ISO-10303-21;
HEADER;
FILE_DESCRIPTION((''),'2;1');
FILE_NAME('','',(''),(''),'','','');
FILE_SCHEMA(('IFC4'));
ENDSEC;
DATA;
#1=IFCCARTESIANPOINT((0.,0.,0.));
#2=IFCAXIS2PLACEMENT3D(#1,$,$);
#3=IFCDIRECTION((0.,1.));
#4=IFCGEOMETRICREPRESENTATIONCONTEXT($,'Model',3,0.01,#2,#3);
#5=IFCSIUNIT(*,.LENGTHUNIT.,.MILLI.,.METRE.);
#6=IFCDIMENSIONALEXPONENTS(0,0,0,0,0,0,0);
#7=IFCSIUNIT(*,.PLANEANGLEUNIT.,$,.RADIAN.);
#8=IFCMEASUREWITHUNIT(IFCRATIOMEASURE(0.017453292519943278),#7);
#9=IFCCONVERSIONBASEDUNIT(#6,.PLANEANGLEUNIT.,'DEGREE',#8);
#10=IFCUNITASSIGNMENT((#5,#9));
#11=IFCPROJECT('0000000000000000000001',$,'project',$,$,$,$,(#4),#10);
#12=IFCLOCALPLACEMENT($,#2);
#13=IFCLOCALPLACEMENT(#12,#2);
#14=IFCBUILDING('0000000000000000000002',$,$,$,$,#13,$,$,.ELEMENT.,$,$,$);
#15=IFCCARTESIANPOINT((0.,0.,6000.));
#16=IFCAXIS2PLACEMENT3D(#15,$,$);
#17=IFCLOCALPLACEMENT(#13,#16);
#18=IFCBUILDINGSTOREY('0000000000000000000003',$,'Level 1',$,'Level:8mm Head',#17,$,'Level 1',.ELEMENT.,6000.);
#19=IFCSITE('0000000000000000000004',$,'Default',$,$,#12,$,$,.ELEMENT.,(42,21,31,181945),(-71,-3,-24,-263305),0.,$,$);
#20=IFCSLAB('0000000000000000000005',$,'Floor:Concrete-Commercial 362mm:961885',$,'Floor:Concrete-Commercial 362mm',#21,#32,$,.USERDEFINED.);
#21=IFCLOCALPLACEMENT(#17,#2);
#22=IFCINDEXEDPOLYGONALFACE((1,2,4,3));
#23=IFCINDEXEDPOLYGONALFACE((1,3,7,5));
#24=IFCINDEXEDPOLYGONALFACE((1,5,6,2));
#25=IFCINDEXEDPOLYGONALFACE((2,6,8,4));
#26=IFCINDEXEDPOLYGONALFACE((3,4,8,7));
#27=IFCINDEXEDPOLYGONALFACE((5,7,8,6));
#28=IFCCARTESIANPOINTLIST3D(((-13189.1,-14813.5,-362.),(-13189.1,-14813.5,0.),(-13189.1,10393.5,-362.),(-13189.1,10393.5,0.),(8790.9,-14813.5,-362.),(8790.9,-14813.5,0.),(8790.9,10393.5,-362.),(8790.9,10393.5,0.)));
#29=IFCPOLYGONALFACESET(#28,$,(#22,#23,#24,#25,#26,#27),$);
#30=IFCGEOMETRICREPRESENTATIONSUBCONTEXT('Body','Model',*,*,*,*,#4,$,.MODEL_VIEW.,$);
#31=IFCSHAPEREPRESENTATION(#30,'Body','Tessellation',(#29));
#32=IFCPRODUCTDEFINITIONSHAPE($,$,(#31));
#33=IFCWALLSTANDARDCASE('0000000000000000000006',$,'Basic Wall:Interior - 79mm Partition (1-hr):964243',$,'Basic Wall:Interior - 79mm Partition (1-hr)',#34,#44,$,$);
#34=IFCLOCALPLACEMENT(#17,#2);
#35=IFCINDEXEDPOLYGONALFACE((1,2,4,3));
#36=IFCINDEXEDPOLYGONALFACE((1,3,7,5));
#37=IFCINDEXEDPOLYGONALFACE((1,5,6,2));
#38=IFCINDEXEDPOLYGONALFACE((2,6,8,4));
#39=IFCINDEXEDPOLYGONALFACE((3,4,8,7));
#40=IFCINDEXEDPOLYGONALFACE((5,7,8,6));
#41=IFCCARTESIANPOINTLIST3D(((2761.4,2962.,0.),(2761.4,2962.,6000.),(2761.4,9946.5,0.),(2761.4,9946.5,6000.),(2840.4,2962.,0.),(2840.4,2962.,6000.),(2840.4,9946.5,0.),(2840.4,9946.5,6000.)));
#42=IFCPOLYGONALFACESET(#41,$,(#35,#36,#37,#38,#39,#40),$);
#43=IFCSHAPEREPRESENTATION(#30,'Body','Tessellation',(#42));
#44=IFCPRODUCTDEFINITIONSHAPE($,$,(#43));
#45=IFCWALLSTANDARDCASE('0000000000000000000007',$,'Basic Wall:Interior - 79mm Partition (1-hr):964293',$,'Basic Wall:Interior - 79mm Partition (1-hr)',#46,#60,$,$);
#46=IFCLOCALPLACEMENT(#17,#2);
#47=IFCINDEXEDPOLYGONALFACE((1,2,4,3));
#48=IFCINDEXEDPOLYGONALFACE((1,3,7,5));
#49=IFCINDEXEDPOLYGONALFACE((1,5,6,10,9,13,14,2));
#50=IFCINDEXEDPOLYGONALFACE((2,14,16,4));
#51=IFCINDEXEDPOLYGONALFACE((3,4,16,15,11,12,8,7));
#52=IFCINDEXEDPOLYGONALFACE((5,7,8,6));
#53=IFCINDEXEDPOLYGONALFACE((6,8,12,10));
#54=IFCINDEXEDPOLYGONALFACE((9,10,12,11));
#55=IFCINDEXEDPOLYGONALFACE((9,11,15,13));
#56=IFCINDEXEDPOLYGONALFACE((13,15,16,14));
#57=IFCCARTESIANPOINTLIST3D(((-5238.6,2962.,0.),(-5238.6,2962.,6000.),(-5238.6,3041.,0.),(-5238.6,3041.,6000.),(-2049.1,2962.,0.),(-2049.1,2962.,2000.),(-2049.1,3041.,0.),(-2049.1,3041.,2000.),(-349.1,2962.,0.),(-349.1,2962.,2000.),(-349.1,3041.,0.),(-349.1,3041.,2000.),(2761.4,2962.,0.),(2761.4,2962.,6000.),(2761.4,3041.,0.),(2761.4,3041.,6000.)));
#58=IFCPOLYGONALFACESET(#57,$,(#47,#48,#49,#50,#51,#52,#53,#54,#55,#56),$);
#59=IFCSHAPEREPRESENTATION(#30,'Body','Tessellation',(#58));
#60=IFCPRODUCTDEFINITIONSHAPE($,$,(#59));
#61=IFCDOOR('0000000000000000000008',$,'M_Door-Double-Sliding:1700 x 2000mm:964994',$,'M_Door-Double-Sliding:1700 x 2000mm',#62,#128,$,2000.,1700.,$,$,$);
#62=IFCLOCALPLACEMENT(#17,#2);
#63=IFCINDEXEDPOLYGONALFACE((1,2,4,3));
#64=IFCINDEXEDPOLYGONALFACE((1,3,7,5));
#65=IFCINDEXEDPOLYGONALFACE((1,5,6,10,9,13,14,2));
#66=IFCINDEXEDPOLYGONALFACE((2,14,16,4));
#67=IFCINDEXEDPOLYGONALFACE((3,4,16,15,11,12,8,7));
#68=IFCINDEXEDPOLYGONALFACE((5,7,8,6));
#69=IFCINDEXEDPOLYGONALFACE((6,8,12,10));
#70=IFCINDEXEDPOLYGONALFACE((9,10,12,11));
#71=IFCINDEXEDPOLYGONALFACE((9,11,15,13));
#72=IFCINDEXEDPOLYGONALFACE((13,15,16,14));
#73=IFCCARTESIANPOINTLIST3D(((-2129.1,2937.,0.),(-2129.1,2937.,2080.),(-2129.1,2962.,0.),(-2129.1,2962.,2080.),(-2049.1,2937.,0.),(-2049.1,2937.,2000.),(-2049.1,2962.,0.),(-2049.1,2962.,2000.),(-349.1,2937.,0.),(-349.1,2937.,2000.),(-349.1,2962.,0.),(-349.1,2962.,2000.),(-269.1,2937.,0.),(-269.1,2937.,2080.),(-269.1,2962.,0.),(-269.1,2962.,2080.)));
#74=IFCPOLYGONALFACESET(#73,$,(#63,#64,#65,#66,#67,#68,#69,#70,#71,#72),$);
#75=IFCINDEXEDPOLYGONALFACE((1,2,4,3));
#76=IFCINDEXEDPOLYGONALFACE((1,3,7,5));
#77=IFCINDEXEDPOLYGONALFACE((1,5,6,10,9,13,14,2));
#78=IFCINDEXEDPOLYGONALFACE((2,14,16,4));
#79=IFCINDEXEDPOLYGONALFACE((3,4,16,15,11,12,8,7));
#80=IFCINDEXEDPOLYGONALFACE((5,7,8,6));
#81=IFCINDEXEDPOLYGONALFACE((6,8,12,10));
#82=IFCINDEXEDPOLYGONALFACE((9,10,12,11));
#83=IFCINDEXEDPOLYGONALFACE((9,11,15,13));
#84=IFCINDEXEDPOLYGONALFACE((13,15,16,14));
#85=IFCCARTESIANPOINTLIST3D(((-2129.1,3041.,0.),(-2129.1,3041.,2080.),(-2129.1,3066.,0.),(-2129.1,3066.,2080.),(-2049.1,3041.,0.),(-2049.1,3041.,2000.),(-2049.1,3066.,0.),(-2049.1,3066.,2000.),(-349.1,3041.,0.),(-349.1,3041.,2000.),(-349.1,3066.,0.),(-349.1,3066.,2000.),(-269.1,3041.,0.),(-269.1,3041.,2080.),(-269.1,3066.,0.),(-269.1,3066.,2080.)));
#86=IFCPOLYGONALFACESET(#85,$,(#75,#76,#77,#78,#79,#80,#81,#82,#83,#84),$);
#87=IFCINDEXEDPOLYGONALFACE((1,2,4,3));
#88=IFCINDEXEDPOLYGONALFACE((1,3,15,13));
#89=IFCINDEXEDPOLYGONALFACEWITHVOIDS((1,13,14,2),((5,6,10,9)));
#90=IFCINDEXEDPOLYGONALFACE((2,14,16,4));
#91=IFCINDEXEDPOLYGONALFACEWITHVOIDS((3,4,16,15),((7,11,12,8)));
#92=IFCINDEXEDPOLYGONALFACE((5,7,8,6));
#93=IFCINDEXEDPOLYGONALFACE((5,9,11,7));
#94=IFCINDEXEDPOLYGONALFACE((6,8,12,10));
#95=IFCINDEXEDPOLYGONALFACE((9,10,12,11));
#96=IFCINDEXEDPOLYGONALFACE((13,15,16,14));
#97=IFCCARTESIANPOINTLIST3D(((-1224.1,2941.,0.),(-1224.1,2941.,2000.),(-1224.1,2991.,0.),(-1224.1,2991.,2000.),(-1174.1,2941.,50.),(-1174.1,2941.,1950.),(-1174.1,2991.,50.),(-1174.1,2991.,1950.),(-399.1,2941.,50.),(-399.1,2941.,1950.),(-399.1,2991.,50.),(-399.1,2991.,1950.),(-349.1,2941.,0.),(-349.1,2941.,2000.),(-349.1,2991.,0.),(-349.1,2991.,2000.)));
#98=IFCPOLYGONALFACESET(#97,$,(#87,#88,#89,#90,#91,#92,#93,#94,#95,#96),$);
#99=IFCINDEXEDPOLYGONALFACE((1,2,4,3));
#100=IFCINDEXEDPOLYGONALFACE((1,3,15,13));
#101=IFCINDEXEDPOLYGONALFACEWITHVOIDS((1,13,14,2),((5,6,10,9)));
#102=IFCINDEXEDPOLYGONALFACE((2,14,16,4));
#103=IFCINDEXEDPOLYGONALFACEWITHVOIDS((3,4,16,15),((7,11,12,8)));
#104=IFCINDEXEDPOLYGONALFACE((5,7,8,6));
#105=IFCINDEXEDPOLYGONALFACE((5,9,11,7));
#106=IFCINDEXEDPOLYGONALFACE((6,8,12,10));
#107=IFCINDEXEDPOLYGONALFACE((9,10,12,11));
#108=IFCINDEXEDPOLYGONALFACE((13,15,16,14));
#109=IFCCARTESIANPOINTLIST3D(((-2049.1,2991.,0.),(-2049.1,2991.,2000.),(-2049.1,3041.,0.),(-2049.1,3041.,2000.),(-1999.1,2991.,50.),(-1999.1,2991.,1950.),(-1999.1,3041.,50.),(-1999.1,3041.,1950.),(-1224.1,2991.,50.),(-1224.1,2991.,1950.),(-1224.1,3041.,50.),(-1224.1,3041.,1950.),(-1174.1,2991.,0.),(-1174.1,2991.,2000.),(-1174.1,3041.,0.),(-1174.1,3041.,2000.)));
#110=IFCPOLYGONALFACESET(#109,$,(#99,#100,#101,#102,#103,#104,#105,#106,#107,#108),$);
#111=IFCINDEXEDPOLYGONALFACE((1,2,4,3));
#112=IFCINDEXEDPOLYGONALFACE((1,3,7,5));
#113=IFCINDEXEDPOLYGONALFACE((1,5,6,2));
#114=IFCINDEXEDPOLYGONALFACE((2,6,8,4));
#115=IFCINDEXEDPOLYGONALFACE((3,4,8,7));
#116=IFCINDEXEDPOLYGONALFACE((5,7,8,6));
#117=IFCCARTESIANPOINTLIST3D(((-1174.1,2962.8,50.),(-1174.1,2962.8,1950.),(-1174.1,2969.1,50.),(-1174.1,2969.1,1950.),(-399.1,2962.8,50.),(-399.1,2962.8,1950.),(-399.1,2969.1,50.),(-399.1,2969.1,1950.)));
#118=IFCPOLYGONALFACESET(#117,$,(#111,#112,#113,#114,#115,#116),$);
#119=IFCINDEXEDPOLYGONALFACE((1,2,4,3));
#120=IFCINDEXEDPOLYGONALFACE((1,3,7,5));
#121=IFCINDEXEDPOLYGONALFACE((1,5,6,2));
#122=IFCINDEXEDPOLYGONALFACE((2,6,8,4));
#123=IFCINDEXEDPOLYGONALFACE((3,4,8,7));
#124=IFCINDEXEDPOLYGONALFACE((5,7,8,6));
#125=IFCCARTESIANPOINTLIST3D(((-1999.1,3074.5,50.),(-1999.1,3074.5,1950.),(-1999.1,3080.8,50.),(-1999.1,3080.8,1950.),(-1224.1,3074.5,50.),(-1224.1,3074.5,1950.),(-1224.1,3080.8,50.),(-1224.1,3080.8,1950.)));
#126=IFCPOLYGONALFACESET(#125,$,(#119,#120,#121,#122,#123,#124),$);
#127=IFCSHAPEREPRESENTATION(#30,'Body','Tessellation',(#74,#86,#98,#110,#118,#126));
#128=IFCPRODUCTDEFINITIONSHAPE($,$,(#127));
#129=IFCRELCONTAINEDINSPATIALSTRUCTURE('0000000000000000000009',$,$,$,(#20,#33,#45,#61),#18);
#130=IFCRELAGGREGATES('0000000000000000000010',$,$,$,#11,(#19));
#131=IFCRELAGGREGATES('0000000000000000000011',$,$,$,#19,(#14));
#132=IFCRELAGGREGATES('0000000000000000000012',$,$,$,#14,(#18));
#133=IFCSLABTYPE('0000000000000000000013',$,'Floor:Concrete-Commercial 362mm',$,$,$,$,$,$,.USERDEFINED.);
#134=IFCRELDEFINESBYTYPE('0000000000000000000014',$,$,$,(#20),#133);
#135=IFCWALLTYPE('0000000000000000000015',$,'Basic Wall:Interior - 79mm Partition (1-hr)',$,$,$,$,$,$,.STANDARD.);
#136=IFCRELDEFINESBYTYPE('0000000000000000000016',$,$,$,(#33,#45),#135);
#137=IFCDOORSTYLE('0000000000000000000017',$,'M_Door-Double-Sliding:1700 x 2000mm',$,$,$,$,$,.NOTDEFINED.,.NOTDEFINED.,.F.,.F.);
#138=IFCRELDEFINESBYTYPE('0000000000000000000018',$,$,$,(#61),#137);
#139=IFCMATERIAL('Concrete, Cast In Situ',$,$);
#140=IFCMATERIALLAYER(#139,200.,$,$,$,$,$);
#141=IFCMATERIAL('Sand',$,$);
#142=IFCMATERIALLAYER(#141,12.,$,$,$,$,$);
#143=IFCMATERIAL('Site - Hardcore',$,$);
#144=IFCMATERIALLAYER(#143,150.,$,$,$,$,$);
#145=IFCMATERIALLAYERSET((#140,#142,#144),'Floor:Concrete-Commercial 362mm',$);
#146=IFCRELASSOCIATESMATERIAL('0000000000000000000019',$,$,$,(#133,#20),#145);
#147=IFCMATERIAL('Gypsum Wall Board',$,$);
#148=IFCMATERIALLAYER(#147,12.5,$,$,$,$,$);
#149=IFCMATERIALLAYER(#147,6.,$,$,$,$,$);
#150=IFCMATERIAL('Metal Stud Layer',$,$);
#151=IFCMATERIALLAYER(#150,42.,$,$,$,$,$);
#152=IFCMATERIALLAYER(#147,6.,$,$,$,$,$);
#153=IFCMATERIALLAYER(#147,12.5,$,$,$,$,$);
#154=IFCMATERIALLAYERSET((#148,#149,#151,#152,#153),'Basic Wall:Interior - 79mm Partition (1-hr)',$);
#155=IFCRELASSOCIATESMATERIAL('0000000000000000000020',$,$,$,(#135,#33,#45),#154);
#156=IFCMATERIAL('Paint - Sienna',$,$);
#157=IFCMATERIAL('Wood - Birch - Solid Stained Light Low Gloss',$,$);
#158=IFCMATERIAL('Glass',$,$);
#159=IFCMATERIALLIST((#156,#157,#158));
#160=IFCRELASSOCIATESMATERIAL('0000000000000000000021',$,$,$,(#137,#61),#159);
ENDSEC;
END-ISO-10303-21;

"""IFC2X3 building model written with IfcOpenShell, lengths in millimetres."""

from ifc_helpers import new_model, entity, si_unit, converted_unit, direction, frame, frame_2d, origin, origin_2d_with_axis, place, context, subcontext, project, spatial, polyline, rectangle, outline, extrude, source, transform, mapped, material, material_list, layer, layer_set, layer_usage, type_object, type_shapes, element, fill, save


model = new_model("IFC2X3")

# Units and contexts
model_context = context("Model", 3, precision=0.01, world=origin(), true_north=direction((0.0, 1.0)))
body_context = subcontext(model_context, "Body", "Model", "MODEL_VIEW")
ifc_project = project(units=[si_unit("LENGTHUNIT", "METRE", prefix="MILLI"), converted_unit("PLANEANGLEUNIT", "DEGREE", entity("IfcRatioMeasure", 0.017453292519943278), si_unit("PLANEANGLEUNIT", "RADIAN"), dimensions=[0, 0, 0, 0, 0, 0, 0])], contexts=[model_context])

# Site, building, storey
site_placement = place(None, origin())
site = spatial("IfcSite", under=ifc_project, at=site_placement, Name="Default", CompositionType="ELEMENT", RefLatitude=(42, 21, 31, 181945), RefLongitude=(-71, -3, -24, -263305), RefElevation=0.0)
building_placement = place(site_placement, origin())
building = spatial("IfcBuilding", under=site, at=building_placement, CompositionType="ELEMENT")
storey_placement = place(building_placement, frame((0.0, 0.0, 6000.0)))
storey = spatial("IfcBuildingStorey", under=building, at=storey_placement, Name="Level 1", ObjectType="Level:8mm Head", LongName="Level 1", CompositionType="ELEMENT", Elevation=6000.0)

# Slab
ifc_material_1 = material(Name="Concrete, Cast In Situ")
ifc_layer_1 = layer(ifc_material_1, 200.0)
ifc_material_2 = material(Name="Sand")
ifc_layer_2 = layer(ifc_material_2, 12.0)
ifc_material_3 = material(Name="Site - Hardcore")
ifc_layer_3 = layer(ifc_material_3, 150.0)
ifc_layer_set_1 = layer_set([ifc_layer_1, ifc_layer_2, ifc_layer_3], Name="Floor:Concrete-Commercial 362mm")
ifc_layer_usage_1 = layer_usage(ifc_layer_set_1, "AXIS3", "POSITIVE", 0.0)
slab_type = type_object("IfcSlabType", Name="Floor:Concrete-Commercial 362mm", PredefinedType="USERDEFINED", material=ifc_layer_set_1)
slab_placement = place(storey_placement, origin())
element("IfcSlab", 1, at=slab_placement, inside=storey, type_object=slab_type, material=ifc_layer_usage_1, Name="Floor:Concrete-Commercial 362mm:961885", ObjectType="Floor:Concrete-Commercial 362mm", PredefinedType="USERDEFINED", context=body_context, shape_type="SweptSolid", body=[
    extrude(rectangle(XDim=25207.0, YDim=21980.0, at=frame_2d((0.0, 0.0), x_axis=(1.0, 0.0))), frame((-2199.1, -2210.0, 0.0), z_axis=(0.0, 0.0, -1.0), x_axis=(0.0, 1.0, 0.0)), (0.0, 0.0, 1.0), 362.0),
])

# Wall
ifc_material_4 = material(Name="Gypsum Wall Board")
ifc_layer_4 = layer(ifc_material_4, 12.5)
ifc_layer_5 = layer(ifc_material_4, 6.0)
ifc_material_5 = material(Name="Metal Stud Layer")
ifc_layer_6 = layer(ifc_material_5, 42.0)
ifc_layer_7 = layer(ifc_material_4, 6.0)
ifc_layer_8 = layer(ifc_material_4, 12.5)
ifc_layer_set_2 = layer_set([ifc_layer_4, ifc_layer_5, ifc_layer_6, ifc_layer_7, ifc_layer_8], Name="Basic Wall:Interior - 79mm Partition (1-hr)")
ifc_layer_usage_2 = layer_usage(ifc_layer_set_2, "AXIS2", "NEGATIVE", 39.5)
wall_type = type_object("IfcWallType", Name="Basic Wall:Interior - 79mm Partition (1-hr)", PredefinedType="STANDARD", material=ifc_layer_set_2)
wall_1_placement = place(storey_placement, frame((2800.9, 9946.5, 0.0), z_axis=(0.0, 0.0, 1.0), x_axis=(0.0, -1.0, 0.0)))
element("IfcWallStandardCase", 2, at=wall_1_placement, inside=storey, type_object=wall_type, material=ifc_layer_usage_2, Name="Basic Wall:Interior - 79mm Partition (1-hr):964243", ObjectType="Basic Wall:Interior - 79mm Partition (1-hr)", context=body_context, shape_type="SweptSolid", body=[
    extrude(rectangle(XDim=6984.5, YDim=79.0, at=frame_2d((3492.3, 0.0), x_axis=(-1.0, 0.0))), origin(), (0.0, 0.0, 1.0), 6000.0),
])

# Wall, opening, door
wall_2_placement = place(storey_placement, frame((2761.4, 3001.5, 0.0), z_axis=(0.0, 0.0, 1.0), x_axis=(-1.0, 0.0, 0.0)))
wall_2 = element("IfcWallStandardCase", 3, at=wall_2_placement, inside=storey, type_object=wall_type, material=ifc_layer_usage_2, Name="Basic Wall:Interior - 79mm Partition (1-hr):964293", ObjectType="Basic Wall:Interior - 79mm Partition (1-hr)", context=body_context, shape_type="SweptSolid", body=[
    extrude(rectangle(XDim=8000.0, YDim=79.0, at=frame_2d((4000.0, 0.0), x_axis=(-1.0, 0.0))), origin(), (0.0, 0.0, 1.0), 6000.0),
])
opening_1_placement = place(wall_2_placement, frame((4810.5, 39.5, 0.0)))
opening_1 = element("IfcOpeningElement", 4, at=opening_1_placement, cuts=wall_2, ObjectType="Opening", context=body_context, shape_type="SweptSolid", body=[
    extrude(rectangle(XDim=2000.0, YDim=1700.0, at=frame_2d((1000.0, 850.0), x_axis=(-1.0, 0.0))), frame((0.0, 0.0, 0.0), z_axis=(0.0, -1.0, 0.0), x_axis=(0.0, 0.0, 1.0)), (0.0, 0.0, 1.0), 79.0),
])
ifc_material_6 = material(Name="Paint - Sienna")
ifc_material_7 = material(Name="Wood - Birch - Solid Stained Light Low Gloss")
ifc_material_8 = material(Name="Glass")
ifc_material_list_1 = material_list([ifc_material_6, ifc_material_7, ifc_material_8])
door_style = type_object("IfcDoorStyle", Name="M_Door-Double-Sliding:1700 x 2000mm", ConstructionType="NOTDEFINED", OperationType="NOTDEFINED", ParameterTakesPrecedence=False, Sizeable=False, material=ifc_material_list_1)
shared_shape_1 = source(origin(), body_context, "Body", "SweptSolid", [
    extrude(outline(polyline([(-1020.0, -930.0), (1060.0, -930.0), (1060.0, 930.0), (-1020.0, 930.0), (-1020.0, 850.0), (980.0, 850.0), (980.0, -850.0), (-1020.0, -850.0), (-1020.0, -930.0)])), frame((850.0, -25.0, 1020.0), z_axis=(0.0, 1.0, 0.0), x_axis=(0.0, 0.0, 1.0)), (0.0, 0.0, 1.0), 25.0),
    extrude(outline(polyline([(-930.0, -1020.0), (-850.0, -1020.0), (-850.0, 980.0), (850.0, 980.0), (850.0, -1020.0), (930.0, -1020.0), (930.0, 1060.0), (-930.0, 1060.0), (-930.0, -1020.0)])), frame((850.0, 79.0, 1020.0), z_axis=(0.0, 1.0, 0.0), x_axis=(-1.0, 0.0, 0.0)), (0.0, 0.0, 1.0), 25.0),
    extrude(outline(polyline([(-437.5, -1000.0), (437.5, -1000.0), (437.5, 1000.0), (-437.5, 1000.0), (-437.5, -1000.0)]), holes=[polyline([(-387.5, -950.0), (-387.5, 950.0), (387.5, 950.0), (387.5, -950.0), (-387.5, -950.0)])]), frame((1262.5, -21.0, 1000.0), z_axis=(0.0, 1.0, 0.0), x_axis=(1.0, 0.0, 0.0)), (0.0, 0.0, 1.0), 50.0),
    extrude(outline(polyline([(-1000.0, -437.5), (1000.0, -437.5), (1000.0, 437.5), (-1000.0, 437.5), (-1000.0, -437.5)]), holes=[polyline([(-950.0, -387.5), (-950.0, 387.5), (950.0, 387.5), (950.0, -387.5), (-950.0, -387.5)])]), frame((437.5, 29.0, 1000.0), z_axis=(0.0, 1.0, 0.0), x_axis=(0.0, 0.0, -1.0)), (0.0, 0.0, 1.0), 50.0),
    extrude(rectangle(XDim=6.3, YDim=775.0, at=frame_2d((0.0, 0.0), x_axis=(1.0, 0.0))), frame((1262.5, 4.0, 50.0), z_axis=(0.0, 0.0, 1.0), x_axis=(0.0, -1.0, 0.0)), (0.0, 0.0, 1.0), 1900.0),
    extrude(rectangle(XDim=6.4, YDim=775.0, at=origin_2d_with_axis()), frame((437.5, 115.7, 50.0), z_axis=(0.0, 0.0, 1.0), x_axis=(0.0, 1.0, 0.0)), (0.0, 0.0, 1.0), 1900.0),
])
type_shapes(door_style, [shared_shape_1])
door_1_placement = place(opening_1_placement, frame((0.0, 0.0, 0.0), z_axis=(0.0, 0.0, 1.0), x_axis=(-1.0, 0.0, 0.0)))
door_1 = element("IfcDoor", 5, at=door_1_placement, inside=storey, type_object=door_style, material=ifc_material_list_1, Name="M_Door-Double-Sliding:1700 x 2000mm:964994", ObjectType="M_Door-Double-Sliding:1700 x 2000mm", OverallHeight=2000.0, OverallWidth=1700.0, context=body_context, shape_type="MappedRepresentation", body=[
    mapped(shared_shape_1, transform((0.0, 0.0, 0.0), scale=1.0)),
])
fill(opening_1, door_1)

save(model, "model.ifc")
